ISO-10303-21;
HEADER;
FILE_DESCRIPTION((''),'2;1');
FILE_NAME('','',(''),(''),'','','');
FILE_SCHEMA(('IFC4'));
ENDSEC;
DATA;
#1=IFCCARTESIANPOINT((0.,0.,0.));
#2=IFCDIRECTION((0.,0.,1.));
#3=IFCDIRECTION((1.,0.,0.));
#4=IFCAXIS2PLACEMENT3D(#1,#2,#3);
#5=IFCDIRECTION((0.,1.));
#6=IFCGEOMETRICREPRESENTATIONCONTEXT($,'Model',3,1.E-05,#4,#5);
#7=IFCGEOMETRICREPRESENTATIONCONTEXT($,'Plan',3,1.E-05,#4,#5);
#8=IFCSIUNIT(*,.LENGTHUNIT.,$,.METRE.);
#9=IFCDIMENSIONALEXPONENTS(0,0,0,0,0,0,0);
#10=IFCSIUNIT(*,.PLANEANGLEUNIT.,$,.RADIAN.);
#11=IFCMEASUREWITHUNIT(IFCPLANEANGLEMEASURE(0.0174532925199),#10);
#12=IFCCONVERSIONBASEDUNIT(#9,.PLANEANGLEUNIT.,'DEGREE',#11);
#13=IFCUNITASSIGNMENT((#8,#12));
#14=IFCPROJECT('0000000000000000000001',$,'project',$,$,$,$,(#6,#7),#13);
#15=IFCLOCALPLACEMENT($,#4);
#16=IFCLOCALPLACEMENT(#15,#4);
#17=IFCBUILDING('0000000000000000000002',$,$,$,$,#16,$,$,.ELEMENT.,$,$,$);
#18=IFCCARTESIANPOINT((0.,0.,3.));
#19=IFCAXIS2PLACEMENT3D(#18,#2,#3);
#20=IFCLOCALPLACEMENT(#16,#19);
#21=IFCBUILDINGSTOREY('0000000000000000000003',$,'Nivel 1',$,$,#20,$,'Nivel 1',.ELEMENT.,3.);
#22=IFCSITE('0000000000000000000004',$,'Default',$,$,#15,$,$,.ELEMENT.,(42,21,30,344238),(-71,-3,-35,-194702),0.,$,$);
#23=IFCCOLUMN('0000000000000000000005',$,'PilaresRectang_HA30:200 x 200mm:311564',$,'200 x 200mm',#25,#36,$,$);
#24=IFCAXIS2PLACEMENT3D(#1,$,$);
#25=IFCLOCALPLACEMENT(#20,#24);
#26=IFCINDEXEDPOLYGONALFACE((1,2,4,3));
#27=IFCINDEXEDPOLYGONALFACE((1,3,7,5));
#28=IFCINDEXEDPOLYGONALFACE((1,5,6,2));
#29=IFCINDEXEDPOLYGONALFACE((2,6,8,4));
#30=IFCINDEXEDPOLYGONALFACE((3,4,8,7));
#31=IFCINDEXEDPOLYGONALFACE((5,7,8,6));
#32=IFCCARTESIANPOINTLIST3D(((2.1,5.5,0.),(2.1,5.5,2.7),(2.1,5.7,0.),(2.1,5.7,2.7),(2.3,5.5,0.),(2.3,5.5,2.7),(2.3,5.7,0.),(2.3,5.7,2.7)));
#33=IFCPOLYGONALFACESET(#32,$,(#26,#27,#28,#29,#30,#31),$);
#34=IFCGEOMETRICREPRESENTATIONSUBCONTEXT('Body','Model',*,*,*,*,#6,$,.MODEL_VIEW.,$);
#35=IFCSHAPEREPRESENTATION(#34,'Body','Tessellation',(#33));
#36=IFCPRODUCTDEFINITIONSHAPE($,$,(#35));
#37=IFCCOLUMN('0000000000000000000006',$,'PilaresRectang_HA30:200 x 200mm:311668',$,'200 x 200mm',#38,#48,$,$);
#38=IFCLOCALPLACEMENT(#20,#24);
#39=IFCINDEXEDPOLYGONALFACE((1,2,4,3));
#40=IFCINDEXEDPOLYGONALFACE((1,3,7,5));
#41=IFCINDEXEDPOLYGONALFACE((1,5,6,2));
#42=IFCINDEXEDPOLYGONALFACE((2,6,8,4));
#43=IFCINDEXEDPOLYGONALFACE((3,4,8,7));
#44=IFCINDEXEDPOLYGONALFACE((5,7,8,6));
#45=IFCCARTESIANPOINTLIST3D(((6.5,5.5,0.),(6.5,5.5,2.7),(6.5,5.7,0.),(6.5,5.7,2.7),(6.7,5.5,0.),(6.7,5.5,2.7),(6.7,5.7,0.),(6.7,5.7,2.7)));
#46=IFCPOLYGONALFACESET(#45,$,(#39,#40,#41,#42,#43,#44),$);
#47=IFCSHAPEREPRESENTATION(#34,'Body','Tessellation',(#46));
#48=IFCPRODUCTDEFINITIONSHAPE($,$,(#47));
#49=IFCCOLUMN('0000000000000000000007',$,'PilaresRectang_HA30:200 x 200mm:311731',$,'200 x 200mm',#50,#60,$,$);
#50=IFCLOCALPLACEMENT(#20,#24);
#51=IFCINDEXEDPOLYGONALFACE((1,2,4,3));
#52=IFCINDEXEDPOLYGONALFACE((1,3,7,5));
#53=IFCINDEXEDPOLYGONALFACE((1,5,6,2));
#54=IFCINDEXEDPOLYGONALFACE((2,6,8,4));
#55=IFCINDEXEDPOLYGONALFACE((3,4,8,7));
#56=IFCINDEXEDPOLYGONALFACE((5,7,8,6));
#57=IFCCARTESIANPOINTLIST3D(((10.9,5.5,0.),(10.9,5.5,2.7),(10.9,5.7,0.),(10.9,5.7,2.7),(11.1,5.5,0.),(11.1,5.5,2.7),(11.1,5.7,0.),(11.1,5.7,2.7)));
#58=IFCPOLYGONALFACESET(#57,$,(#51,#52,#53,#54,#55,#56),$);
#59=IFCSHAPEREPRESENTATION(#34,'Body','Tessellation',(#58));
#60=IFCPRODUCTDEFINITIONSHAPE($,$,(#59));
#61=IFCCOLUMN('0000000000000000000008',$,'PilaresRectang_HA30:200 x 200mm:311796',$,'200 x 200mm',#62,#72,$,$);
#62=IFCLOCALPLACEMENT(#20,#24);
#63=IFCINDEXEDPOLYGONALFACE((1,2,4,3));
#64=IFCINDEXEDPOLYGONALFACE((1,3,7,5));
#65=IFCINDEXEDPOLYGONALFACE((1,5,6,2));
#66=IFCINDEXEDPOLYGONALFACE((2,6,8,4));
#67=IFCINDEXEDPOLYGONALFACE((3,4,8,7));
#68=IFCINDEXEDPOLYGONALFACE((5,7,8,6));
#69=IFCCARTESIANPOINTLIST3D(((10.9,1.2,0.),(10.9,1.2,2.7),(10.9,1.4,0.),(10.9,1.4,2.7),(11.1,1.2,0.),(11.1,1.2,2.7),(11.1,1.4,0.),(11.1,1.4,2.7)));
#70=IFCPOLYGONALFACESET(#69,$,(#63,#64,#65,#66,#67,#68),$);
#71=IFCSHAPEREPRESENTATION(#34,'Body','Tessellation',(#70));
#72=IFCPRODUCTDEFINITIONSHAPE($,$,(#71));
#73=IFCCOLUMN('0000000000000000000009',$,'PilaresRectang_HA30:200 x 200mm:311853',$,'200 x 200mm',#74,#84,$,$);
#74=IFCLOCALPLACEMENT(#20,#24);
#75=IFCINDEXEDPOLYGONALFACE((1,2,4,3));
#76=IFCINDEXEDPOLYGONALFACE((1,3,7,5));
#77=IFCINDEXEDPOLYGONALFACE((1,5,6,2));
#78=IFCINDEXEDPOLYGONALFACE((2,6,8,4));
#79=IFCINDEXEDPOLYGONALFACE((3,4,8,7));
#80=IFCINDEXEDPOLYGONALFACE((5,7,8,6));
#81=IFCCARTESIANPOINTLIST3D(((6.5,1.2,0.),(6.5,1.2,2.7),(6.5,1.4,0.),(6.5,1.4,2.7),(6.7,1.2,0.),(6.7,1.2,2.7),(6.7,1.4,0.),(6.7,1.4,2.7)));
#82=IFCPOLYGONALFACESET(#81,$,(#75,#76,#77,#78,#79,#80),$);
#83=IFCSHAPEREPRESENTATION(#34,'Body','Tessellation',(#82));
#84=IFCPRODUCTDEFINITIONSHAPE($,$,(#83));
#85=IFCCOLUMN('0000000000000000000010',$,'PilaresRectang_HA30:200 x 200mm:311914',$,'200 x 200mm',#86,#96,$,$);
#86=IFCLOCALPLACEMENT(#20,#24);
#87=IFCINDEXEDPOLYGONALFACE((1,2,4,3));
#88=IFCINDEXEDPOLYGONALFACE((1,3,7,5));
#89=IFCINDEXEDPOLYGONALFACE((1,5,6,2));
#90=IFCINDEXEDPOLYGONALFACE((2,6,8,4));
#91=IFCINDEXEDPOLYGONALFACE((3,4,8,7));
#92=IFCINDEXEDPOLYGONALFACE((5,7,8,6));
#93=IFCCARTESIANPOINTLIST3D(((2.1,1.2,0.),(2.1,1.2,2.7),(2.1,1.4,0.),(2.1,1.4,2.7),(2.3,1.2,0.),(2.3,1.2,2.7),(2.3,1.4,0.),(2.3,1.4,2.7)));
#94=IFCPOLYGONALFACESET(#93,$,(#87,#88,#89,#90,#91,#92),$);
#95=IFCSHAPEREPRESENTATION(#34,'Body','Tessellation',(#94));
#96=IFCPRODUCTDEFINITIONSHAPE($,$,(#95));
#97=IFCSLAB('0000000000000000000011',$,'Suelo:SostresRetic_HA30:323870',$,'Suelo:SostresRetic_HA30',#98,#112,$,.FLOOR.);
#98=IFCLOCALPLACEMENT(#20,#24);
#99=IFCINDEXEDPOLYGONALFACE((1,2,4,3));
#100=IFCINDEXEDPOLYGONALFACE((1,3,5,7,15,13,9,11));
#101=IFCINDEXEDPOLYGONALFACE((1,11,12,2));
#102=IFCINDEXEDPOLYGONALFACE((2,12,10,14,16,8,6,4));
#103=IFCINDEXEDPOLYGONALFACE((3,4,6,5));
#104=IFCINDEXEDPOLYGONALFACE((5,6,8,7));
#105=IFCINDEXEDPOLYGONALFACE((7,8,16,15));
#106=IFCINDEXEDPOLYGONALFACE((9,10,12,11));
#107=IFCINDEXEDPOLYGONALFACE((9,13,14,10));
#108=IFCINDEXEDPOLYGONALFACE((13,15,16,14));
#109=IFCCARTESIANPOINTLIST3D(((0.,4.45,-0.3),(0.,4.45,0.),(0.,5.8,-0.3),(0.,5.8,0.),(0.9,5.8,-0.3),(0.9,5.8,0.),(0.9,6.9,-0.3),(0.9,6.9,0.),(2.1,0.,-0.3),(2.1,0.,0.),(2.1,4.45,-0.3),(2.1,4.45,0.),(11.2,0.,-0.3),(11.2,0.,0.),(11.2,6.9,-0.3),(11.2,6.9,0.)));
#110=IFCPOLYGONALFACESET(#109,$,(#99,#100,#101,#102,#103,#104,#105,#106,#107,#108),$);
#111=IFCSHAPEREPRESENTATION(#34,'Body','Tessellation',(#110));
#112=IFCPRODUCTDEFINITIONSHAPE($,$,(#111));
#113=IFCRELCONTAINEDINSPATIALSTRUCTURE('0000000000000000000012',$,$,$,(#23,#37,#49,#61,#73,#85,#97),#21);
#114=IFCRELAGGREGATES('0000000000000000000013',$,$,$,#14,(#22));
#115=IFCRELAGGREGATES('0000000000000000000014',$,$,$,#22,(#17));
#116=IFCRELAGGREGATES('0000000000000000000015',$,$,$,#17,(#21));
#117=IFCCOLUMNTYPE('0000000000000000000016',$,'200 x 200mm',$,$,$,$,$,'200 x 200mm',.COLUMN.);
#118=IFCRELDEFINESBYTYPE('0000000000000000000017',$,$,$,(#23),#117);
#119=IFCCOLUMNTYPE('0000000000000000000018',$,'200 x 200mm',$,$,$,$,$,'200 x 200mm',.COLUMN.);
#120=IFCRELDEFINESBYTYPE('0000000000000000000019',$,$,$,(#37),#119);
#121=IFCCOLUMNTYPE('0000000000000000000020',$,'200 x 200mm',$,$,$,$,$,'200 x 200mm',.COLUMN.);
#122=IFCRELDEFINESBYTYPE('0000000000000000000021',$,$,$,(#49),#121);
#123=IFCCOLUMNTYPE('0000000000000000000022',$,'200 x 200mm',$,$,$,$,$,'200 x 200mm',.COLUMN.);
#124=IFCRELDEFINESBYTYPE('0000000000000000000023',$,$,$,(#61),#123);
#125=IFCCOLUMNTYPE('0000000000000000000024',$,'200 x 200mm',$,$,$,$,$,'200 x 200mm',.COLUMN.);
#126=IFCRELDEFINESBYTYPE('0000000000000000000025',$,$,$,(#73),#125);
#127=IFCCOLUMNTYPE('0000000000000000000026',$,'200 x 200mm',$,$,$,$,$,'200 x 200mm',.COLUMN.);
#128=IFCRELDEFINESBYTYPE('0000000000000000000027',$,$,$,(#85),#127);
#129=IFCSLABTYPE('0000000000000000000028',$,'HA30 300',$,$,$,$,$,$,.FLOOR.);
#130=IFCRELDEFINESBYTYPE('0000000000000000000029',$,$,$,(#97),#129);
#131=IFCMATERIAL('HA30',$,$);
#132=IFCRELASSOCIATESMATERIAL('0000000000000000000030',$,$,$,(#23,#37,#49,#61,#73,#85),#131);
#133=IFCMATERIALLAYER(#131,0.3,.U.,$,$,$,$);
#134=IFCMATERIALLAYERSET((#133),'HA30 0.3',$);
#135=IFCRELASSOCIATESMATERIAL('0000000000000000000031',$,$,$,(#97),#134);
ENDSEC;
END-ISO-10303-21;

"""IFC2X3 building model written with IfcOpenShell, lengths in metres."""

from ifc_helpers import new_model, entity, si_unit, converted_unit, direction, frame, origin_with_axes, origin_2d_with_axis, place, context, subcontext, project, spatial, polyline, rectangle, outline, extrude, material, layer, layer_set, layer_usage, type_object, element, save


model = new_model("IFC2X3")

# Units and contexts
model_context = context("Model", 3, precision=1e-05, world=origin_with_axes(), true_north=direction((0.0, 1.0)))
plan_context = context("Plan", 3, precision=1e-05, world=origin_with_axes(), true_north=direction((0.0, 1.0)))
body_context = subcontext(model_context, "Body", "Model", "MODEL_VIEW")
ifc_project = project(units=[si_unit("LENGTHUNIT", "METRE"), converted_unit("PLANEANGLEUNIT", "DEGREE", entity("IfcPlaneAngleMeasure", 0.0174532925199), si_unit("PLANEANGLEUNIT", "RADIAN"), dimensions=[0, 0, 0, 0, 0, 0, 0])], contexts=[model_context, plan_context])

# Site, building, storey
site_placement = place(None, origin_with_axes())
site = spatial("IfcSite", under=ifc_project, at=site_placement, Name="Default", CompositionType="ELEMENT", RefLatitude=(42, 21, 30, 344238), RefLongitude=(-71, -3, -35, -194702), RefElevation=0.0)
building_placement = place(site_placement, origin_with_axes())
building = spatial("IfcBuilding", under=site, at=building_placement, CompositionType="ELEMENT")
storey_placement = place(building_placement, frame((0.0, 0.0, 3.0), z_axis=(0.0, 0.0, 1.0), x_axis=(1.0, 0.0, 0.0)))
storey = spatial("IfcBuildingStorey", under=building, at=storey_placement, Name="Nivel 1", LongName="Nivel 1", CompositionType="ELEMENT", Elevation=3.0)

# Columns
ifc_material = material(Name="HA30")
column_type_1 = type_object("IfcColumnType", Name="200 x 200mm", ElementType="200 x 200mm", PredefinedType="COLUMN")
column_1_placement = place(storey_placement, frame((2.2, 5.6, 0.0), z_axis=(0.0, 0.0, 1.0), x_axis=(0.0, -1.0, 0.0)))
element("IfcColumn", 1, at=column_1_placement, inside=storey, type_object=column_type_1, material=ifc_material, Name="PilaresRectang_HA30:200 x 200mm:311564", ObjectType="200 x 200mm", context=body_context, shape_type="SweptSolid", body=[
    extrude(rectangle(XDim=0.2, YDim=0.2, at=origin_2d_with_axis()), origin_with_axes(), (0.0, 0.0, 1.0), 2.7),
])
column_type_2 = type_object("IfcColumnType", Name="200 x 200mm", ElementType="200 x 200mm", PredefinedType="COLUMN")
column_2_placement = place(storey_placement, frame((6.6, 5.6, 0.0), z_axis=(0.0, 0.0, 1.0), x_axis=(0.0, -1.0, 0.0)))
element("IfcColumn", 2, at=column_2_placement, inside=storey, type_object=column_type_2, material=ifc_material, Name="PilaresRectang_HA30:200 x 200mm:311668", ObjectType="200 x 200mm", context=body_context, shape_type="SweptSolid", body=[
    extrude(rectangle(XDim=0.2, YDim=0.2, at=origin_2d_with_axis()), origin_with_axes(), (0.0, 0.0, 1.0), 2.7),
])
column_type_3 = type_object("IfcColumnType", Name="200 x 200mm", ElementType="200 x 200mm", PredefinedType="COLUMN")
column_3_placement = place(storey_placement, frame((11.0, 5.6, 0.0), z_axis=(0.0, 0.0, 1.0), x_axis=(0.0, -1.0, 0.0)))
element("IfcColumn", 3, at=column_3_placement, inside=storey, type_object=column_type_3, material=ifc_material, Name="PilaresRectang_HA30:200 x 200mm:311731", ObjectType="200 x 200mm", context=body_context, shape_type="SweptSolid", body=[
    extrude(rectangle(XDim=0.2, YDim=0.2, at=origin_2d_with_axis()), origin_with_axes(), (0.0, 0.0, 1.0), 2.7),
])
column_type_4 = type_object("IfcColumnType", Name="200 x 200mm", ElementType="200 x 200mm", PredefinedType="COLUMN")
column_4_placement = place(storey_placement, frame((11.0, 1.3, 0.0), z_axis=(0.0, 0.0, 1.0), x_axis=(0.0, -1.0, 0.0)))
element("IfcColumn", 4, at=column_4_placement, inside=storey, type_object=column_type_4, material=ifc_material, Name="PilaresRectang_HA30:200 x 200mm:311796", ObjectType="200 x 200mm", context=body_context, shape_type="SweptSolid", body=[
    extrude(rectangle(XDim=0.2, YDim=0.2, at=origin_2d_with_axis()), origin_with_axes(), (0.0, 0.0, 1.0), 2.7),
])
column_type_5 = type_object("IfcColumnType", Name="200 x 200mm", ElementType="200 x 200mm", PredefinedType="COLUMN")
column_5_placement = place(storey_placement, frame((6.6, 1.3, 0.0), z_axis=(0.0, 0.0, 1.0), x_axis=(0.0, -1.0, 0.0)))
element("IfcColumn", 5, at=column_5_placement, inside=storey, type_object=column_type_5, material=ifc_material, Name="PilaresRectang_HA30:200 x 200mm:311853", ObjectType="200 x 200mm", context=body_context, shape_type="SweptSolid", body=[
    extrude(rectangle(XDim=0.2, YDim=0.2, at=origin_2d_with_axis()), origin_with_axes(), (0.0, 0.0, 1.0), 2.7),
])
column_type_6 = type_object("IfcColumnType", Name="200 x 200mm", ElementType="200 x 200mm", PredefinedType="COLUMN")
column_6_placement = place(storey_placement, frame((2.2, 1.3, 0.0), z_axis=(0.0, 0.0, 1.0), x_axis=(0.0, -1.0, 0.0)))
element("IfcColumn", 6, at=column_6_placement, inside=storey, type_object=column_type_6, material=ifc_material, Name="PilaresRectang_HA30:200 x 200mm:311914", ObjectType="200 x 200mm", context=body_context, shape_type="SweptSolid", body=[
    extrude(rectangle(XDim=0.2, YDim=0.2, at=origin_2d_with_axis()), origin_with_axes(), (0.0, 0.0, 1.0), 2.7),
])

# Slab
ifc_layer = layer(ifc_material, 0.3, ventilated="UNKNOWN")
ifc_layer_set = layer_set([ifc_layer], Name="HA30 0.3")
ifc_layer_usage = layer_usage(ifc_layer_set, "AXIS3", "NEGATIVE", 0.3)
slab_type = type_object("IfcSlabType", Name="HA30 300", PredefinedType="FLOOR")
slab_placement = place(storey_placement, frame((0.0, 4.45, 0.0), z_axis=(0.0, 0.0, 1.0), x_axis=(1.0, 0.0, 0.0)))
element("IfcSlab", 7, at=slab_placement, inside=storey, type_object=slab_type, material=ifc_layer_usage, Name="Suelo:SostresRetic_HA30:323870", ObjectType="Suelo:SostresRetic_HA30", PredefinedType="FLOOR", context=body_context, shape_type="SweptSolid", body=[
    extrude(outline(polyline([(0.0, 0.0), (2.1, 0.0), (2.1, -4.45), (11.2, -4.45), (11.2, 2.45), (0.9, 2.45), (0.9, 1.35), (0.0, 1.35), (0.0, 0.0)])), frame((0.0, 0.0, -0.3), z_axis=(0.0, 0.0, 1.0), x_axis=(1.0, 0.0, 0.0)), (0.0, 0.0, 1.0), 0.3),
])

save(model, "model.ifc")
